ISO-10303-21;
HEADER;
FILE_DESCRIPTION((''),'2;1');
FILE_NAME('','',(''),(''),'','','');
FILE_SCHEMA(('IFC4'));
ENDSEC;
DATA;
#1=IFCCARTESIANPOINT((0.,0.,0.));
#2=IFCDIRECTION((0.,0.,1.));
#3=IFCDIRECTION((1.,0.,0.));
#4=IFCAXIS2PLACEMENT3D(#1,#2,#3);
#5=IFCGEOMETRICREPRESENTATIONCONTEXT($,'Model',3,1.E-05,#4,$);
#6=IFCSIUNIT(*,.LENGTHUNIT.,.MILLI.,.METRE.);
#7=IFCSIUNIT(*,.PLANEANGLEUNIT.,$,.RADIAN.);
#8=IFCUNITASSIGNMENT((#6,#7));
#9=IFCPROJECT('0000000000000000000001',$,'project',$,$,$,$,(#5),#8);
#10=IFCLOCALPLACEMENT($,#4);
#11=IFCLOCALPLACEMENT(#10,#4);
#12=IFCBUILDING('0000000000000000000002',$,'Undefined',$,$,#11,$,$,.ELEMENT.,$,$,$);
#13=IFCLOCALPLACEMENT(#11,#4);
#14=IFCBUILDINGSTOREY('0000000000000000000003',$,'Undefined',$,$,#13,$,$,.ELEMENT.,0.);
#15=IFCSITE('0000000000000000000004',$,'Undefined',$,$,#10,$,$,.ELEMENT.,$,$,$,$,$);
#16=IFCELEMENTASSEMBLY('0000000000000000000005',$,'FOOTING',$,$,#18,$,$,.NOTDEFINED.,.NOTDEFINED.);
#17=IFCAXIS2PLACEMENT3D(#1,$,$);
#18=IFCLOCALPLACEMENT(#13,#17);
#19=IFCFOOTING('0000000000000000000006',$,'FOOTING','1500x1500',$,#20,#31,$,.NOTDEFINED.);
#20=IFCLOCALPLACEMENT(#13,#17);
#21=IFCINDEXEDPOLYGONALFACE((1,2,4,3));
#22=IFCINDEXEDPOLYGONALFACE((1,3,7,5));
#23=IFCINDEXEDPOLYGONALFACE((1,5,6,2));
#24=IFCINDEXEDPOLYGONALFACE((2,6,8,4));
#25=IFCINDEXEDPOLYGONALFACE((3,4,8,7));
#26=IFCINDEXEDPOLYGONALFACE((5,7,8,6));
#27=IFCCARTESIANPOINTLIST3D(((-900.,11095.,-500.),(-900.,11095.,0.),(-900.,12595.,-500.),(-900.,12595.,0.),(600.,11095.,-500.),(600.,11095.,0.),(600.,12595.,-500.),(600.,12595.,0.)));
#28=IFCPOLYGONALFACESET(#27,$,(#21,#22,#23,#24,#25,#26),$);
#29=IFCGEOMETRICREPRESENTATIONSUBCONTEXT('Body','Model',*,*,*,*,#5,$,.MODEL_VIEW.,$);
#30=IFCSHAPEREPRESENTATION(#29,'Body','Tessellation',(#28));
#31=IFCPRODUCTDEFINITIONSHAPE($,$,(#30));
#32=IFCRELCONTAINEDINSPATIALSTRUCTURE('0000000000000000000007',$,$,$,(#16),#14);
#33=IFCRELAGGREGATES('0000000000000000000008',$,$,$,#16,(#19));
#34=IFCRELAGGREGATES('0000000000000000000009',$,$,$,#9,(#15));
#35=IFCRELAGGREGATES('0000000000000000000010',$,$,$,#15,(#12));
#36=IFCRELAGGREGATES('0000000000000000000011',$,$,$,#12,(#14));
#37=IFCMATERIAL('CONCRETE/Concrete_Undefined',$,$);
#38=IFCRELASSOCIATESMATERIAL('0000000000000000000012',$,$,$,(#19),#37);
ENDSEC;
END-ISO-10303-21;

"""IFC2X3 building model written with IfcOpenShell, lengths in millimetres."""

from ifc_helpers import new_model, si_unit, frame, origin_with_axes, origin_2d_with_axis, place, context, subcontext, project, spatial, rectangle, extrude, material, element, aggregate, save


model = new_model("IFC2X3")

# Units and contexts
model_context = context("Model", 3, precision=1e-05, world=origin_with_axes())
body_context = subcontext(model_context, "Body", "Model", "MODEL_VIEW")
ifc_project = project(units=[si_unit("LENGTHUNIT", "METRE", prefix="MILLI"), si_unit("PLANEANGLEUNIT", "RADIAN")], contexts=[model_context])

# Site, building, storey
site_placement = place(None, origin_with_axes())
site = spatial("IfcSite", under=ifc_project, at=site_placement, Name="Undefined", CompositionType="ELEMENT")
building_placement = place(site_placement, origin_with_axes())
building = spatial("IfcBuilding", under=site, at=building_placement, Name="Undefined", CompositionType="ELEMENT")
storey_placement = place(building_placement, origin_with_axes())
storey = spatial("IfcBuildingStorey", under=building, at=storey_placement, Name="Undefined", CompositionType="ELEMENT", Elevation=0.0)

# Element assembly, footing
assembly_1_placement = place(storey_placement, origin_with_axes())
assembly_1 = element("IfcElementAssembly", 1, at=assembly_1_placement, inside=storey, Name="FOOTING", AssemblyPlace="NOTDEFINED", PredefinedType="NOTDEFINED")
ifc_material_1 = material(Name="CONCRETE/Concrete_Undefined")
footing_placement = place(assembly_1_placement, frame((-150.0, 11845.0, -500.0), z_axis=(0.0, 1.0, 0.0), x_axis=(0.0, 0.0, 1.0)))
footing = element("IfcFooting", 2, at=footing_placement, material=ifc_material_1, Name="FOOTING", Description="1500x1500", PredefinedType="NOTDEFINED", context=body_context, shape_type="SweptSolid", body=[
    extrude(rectangle(XDim=1500.0, YDim=1500.0, at=origin_2d_with_axis()), frame((500.0, 0.0, 0.0), z_axis=(-1.0, 0.0, 0.0), x_axis=(0.0, -1.0, 0.0)), (0.0, 0.0, 1.0), 500.0),
])
aggregate(assembly_1, [footing])

save(model, "model.ifc")
